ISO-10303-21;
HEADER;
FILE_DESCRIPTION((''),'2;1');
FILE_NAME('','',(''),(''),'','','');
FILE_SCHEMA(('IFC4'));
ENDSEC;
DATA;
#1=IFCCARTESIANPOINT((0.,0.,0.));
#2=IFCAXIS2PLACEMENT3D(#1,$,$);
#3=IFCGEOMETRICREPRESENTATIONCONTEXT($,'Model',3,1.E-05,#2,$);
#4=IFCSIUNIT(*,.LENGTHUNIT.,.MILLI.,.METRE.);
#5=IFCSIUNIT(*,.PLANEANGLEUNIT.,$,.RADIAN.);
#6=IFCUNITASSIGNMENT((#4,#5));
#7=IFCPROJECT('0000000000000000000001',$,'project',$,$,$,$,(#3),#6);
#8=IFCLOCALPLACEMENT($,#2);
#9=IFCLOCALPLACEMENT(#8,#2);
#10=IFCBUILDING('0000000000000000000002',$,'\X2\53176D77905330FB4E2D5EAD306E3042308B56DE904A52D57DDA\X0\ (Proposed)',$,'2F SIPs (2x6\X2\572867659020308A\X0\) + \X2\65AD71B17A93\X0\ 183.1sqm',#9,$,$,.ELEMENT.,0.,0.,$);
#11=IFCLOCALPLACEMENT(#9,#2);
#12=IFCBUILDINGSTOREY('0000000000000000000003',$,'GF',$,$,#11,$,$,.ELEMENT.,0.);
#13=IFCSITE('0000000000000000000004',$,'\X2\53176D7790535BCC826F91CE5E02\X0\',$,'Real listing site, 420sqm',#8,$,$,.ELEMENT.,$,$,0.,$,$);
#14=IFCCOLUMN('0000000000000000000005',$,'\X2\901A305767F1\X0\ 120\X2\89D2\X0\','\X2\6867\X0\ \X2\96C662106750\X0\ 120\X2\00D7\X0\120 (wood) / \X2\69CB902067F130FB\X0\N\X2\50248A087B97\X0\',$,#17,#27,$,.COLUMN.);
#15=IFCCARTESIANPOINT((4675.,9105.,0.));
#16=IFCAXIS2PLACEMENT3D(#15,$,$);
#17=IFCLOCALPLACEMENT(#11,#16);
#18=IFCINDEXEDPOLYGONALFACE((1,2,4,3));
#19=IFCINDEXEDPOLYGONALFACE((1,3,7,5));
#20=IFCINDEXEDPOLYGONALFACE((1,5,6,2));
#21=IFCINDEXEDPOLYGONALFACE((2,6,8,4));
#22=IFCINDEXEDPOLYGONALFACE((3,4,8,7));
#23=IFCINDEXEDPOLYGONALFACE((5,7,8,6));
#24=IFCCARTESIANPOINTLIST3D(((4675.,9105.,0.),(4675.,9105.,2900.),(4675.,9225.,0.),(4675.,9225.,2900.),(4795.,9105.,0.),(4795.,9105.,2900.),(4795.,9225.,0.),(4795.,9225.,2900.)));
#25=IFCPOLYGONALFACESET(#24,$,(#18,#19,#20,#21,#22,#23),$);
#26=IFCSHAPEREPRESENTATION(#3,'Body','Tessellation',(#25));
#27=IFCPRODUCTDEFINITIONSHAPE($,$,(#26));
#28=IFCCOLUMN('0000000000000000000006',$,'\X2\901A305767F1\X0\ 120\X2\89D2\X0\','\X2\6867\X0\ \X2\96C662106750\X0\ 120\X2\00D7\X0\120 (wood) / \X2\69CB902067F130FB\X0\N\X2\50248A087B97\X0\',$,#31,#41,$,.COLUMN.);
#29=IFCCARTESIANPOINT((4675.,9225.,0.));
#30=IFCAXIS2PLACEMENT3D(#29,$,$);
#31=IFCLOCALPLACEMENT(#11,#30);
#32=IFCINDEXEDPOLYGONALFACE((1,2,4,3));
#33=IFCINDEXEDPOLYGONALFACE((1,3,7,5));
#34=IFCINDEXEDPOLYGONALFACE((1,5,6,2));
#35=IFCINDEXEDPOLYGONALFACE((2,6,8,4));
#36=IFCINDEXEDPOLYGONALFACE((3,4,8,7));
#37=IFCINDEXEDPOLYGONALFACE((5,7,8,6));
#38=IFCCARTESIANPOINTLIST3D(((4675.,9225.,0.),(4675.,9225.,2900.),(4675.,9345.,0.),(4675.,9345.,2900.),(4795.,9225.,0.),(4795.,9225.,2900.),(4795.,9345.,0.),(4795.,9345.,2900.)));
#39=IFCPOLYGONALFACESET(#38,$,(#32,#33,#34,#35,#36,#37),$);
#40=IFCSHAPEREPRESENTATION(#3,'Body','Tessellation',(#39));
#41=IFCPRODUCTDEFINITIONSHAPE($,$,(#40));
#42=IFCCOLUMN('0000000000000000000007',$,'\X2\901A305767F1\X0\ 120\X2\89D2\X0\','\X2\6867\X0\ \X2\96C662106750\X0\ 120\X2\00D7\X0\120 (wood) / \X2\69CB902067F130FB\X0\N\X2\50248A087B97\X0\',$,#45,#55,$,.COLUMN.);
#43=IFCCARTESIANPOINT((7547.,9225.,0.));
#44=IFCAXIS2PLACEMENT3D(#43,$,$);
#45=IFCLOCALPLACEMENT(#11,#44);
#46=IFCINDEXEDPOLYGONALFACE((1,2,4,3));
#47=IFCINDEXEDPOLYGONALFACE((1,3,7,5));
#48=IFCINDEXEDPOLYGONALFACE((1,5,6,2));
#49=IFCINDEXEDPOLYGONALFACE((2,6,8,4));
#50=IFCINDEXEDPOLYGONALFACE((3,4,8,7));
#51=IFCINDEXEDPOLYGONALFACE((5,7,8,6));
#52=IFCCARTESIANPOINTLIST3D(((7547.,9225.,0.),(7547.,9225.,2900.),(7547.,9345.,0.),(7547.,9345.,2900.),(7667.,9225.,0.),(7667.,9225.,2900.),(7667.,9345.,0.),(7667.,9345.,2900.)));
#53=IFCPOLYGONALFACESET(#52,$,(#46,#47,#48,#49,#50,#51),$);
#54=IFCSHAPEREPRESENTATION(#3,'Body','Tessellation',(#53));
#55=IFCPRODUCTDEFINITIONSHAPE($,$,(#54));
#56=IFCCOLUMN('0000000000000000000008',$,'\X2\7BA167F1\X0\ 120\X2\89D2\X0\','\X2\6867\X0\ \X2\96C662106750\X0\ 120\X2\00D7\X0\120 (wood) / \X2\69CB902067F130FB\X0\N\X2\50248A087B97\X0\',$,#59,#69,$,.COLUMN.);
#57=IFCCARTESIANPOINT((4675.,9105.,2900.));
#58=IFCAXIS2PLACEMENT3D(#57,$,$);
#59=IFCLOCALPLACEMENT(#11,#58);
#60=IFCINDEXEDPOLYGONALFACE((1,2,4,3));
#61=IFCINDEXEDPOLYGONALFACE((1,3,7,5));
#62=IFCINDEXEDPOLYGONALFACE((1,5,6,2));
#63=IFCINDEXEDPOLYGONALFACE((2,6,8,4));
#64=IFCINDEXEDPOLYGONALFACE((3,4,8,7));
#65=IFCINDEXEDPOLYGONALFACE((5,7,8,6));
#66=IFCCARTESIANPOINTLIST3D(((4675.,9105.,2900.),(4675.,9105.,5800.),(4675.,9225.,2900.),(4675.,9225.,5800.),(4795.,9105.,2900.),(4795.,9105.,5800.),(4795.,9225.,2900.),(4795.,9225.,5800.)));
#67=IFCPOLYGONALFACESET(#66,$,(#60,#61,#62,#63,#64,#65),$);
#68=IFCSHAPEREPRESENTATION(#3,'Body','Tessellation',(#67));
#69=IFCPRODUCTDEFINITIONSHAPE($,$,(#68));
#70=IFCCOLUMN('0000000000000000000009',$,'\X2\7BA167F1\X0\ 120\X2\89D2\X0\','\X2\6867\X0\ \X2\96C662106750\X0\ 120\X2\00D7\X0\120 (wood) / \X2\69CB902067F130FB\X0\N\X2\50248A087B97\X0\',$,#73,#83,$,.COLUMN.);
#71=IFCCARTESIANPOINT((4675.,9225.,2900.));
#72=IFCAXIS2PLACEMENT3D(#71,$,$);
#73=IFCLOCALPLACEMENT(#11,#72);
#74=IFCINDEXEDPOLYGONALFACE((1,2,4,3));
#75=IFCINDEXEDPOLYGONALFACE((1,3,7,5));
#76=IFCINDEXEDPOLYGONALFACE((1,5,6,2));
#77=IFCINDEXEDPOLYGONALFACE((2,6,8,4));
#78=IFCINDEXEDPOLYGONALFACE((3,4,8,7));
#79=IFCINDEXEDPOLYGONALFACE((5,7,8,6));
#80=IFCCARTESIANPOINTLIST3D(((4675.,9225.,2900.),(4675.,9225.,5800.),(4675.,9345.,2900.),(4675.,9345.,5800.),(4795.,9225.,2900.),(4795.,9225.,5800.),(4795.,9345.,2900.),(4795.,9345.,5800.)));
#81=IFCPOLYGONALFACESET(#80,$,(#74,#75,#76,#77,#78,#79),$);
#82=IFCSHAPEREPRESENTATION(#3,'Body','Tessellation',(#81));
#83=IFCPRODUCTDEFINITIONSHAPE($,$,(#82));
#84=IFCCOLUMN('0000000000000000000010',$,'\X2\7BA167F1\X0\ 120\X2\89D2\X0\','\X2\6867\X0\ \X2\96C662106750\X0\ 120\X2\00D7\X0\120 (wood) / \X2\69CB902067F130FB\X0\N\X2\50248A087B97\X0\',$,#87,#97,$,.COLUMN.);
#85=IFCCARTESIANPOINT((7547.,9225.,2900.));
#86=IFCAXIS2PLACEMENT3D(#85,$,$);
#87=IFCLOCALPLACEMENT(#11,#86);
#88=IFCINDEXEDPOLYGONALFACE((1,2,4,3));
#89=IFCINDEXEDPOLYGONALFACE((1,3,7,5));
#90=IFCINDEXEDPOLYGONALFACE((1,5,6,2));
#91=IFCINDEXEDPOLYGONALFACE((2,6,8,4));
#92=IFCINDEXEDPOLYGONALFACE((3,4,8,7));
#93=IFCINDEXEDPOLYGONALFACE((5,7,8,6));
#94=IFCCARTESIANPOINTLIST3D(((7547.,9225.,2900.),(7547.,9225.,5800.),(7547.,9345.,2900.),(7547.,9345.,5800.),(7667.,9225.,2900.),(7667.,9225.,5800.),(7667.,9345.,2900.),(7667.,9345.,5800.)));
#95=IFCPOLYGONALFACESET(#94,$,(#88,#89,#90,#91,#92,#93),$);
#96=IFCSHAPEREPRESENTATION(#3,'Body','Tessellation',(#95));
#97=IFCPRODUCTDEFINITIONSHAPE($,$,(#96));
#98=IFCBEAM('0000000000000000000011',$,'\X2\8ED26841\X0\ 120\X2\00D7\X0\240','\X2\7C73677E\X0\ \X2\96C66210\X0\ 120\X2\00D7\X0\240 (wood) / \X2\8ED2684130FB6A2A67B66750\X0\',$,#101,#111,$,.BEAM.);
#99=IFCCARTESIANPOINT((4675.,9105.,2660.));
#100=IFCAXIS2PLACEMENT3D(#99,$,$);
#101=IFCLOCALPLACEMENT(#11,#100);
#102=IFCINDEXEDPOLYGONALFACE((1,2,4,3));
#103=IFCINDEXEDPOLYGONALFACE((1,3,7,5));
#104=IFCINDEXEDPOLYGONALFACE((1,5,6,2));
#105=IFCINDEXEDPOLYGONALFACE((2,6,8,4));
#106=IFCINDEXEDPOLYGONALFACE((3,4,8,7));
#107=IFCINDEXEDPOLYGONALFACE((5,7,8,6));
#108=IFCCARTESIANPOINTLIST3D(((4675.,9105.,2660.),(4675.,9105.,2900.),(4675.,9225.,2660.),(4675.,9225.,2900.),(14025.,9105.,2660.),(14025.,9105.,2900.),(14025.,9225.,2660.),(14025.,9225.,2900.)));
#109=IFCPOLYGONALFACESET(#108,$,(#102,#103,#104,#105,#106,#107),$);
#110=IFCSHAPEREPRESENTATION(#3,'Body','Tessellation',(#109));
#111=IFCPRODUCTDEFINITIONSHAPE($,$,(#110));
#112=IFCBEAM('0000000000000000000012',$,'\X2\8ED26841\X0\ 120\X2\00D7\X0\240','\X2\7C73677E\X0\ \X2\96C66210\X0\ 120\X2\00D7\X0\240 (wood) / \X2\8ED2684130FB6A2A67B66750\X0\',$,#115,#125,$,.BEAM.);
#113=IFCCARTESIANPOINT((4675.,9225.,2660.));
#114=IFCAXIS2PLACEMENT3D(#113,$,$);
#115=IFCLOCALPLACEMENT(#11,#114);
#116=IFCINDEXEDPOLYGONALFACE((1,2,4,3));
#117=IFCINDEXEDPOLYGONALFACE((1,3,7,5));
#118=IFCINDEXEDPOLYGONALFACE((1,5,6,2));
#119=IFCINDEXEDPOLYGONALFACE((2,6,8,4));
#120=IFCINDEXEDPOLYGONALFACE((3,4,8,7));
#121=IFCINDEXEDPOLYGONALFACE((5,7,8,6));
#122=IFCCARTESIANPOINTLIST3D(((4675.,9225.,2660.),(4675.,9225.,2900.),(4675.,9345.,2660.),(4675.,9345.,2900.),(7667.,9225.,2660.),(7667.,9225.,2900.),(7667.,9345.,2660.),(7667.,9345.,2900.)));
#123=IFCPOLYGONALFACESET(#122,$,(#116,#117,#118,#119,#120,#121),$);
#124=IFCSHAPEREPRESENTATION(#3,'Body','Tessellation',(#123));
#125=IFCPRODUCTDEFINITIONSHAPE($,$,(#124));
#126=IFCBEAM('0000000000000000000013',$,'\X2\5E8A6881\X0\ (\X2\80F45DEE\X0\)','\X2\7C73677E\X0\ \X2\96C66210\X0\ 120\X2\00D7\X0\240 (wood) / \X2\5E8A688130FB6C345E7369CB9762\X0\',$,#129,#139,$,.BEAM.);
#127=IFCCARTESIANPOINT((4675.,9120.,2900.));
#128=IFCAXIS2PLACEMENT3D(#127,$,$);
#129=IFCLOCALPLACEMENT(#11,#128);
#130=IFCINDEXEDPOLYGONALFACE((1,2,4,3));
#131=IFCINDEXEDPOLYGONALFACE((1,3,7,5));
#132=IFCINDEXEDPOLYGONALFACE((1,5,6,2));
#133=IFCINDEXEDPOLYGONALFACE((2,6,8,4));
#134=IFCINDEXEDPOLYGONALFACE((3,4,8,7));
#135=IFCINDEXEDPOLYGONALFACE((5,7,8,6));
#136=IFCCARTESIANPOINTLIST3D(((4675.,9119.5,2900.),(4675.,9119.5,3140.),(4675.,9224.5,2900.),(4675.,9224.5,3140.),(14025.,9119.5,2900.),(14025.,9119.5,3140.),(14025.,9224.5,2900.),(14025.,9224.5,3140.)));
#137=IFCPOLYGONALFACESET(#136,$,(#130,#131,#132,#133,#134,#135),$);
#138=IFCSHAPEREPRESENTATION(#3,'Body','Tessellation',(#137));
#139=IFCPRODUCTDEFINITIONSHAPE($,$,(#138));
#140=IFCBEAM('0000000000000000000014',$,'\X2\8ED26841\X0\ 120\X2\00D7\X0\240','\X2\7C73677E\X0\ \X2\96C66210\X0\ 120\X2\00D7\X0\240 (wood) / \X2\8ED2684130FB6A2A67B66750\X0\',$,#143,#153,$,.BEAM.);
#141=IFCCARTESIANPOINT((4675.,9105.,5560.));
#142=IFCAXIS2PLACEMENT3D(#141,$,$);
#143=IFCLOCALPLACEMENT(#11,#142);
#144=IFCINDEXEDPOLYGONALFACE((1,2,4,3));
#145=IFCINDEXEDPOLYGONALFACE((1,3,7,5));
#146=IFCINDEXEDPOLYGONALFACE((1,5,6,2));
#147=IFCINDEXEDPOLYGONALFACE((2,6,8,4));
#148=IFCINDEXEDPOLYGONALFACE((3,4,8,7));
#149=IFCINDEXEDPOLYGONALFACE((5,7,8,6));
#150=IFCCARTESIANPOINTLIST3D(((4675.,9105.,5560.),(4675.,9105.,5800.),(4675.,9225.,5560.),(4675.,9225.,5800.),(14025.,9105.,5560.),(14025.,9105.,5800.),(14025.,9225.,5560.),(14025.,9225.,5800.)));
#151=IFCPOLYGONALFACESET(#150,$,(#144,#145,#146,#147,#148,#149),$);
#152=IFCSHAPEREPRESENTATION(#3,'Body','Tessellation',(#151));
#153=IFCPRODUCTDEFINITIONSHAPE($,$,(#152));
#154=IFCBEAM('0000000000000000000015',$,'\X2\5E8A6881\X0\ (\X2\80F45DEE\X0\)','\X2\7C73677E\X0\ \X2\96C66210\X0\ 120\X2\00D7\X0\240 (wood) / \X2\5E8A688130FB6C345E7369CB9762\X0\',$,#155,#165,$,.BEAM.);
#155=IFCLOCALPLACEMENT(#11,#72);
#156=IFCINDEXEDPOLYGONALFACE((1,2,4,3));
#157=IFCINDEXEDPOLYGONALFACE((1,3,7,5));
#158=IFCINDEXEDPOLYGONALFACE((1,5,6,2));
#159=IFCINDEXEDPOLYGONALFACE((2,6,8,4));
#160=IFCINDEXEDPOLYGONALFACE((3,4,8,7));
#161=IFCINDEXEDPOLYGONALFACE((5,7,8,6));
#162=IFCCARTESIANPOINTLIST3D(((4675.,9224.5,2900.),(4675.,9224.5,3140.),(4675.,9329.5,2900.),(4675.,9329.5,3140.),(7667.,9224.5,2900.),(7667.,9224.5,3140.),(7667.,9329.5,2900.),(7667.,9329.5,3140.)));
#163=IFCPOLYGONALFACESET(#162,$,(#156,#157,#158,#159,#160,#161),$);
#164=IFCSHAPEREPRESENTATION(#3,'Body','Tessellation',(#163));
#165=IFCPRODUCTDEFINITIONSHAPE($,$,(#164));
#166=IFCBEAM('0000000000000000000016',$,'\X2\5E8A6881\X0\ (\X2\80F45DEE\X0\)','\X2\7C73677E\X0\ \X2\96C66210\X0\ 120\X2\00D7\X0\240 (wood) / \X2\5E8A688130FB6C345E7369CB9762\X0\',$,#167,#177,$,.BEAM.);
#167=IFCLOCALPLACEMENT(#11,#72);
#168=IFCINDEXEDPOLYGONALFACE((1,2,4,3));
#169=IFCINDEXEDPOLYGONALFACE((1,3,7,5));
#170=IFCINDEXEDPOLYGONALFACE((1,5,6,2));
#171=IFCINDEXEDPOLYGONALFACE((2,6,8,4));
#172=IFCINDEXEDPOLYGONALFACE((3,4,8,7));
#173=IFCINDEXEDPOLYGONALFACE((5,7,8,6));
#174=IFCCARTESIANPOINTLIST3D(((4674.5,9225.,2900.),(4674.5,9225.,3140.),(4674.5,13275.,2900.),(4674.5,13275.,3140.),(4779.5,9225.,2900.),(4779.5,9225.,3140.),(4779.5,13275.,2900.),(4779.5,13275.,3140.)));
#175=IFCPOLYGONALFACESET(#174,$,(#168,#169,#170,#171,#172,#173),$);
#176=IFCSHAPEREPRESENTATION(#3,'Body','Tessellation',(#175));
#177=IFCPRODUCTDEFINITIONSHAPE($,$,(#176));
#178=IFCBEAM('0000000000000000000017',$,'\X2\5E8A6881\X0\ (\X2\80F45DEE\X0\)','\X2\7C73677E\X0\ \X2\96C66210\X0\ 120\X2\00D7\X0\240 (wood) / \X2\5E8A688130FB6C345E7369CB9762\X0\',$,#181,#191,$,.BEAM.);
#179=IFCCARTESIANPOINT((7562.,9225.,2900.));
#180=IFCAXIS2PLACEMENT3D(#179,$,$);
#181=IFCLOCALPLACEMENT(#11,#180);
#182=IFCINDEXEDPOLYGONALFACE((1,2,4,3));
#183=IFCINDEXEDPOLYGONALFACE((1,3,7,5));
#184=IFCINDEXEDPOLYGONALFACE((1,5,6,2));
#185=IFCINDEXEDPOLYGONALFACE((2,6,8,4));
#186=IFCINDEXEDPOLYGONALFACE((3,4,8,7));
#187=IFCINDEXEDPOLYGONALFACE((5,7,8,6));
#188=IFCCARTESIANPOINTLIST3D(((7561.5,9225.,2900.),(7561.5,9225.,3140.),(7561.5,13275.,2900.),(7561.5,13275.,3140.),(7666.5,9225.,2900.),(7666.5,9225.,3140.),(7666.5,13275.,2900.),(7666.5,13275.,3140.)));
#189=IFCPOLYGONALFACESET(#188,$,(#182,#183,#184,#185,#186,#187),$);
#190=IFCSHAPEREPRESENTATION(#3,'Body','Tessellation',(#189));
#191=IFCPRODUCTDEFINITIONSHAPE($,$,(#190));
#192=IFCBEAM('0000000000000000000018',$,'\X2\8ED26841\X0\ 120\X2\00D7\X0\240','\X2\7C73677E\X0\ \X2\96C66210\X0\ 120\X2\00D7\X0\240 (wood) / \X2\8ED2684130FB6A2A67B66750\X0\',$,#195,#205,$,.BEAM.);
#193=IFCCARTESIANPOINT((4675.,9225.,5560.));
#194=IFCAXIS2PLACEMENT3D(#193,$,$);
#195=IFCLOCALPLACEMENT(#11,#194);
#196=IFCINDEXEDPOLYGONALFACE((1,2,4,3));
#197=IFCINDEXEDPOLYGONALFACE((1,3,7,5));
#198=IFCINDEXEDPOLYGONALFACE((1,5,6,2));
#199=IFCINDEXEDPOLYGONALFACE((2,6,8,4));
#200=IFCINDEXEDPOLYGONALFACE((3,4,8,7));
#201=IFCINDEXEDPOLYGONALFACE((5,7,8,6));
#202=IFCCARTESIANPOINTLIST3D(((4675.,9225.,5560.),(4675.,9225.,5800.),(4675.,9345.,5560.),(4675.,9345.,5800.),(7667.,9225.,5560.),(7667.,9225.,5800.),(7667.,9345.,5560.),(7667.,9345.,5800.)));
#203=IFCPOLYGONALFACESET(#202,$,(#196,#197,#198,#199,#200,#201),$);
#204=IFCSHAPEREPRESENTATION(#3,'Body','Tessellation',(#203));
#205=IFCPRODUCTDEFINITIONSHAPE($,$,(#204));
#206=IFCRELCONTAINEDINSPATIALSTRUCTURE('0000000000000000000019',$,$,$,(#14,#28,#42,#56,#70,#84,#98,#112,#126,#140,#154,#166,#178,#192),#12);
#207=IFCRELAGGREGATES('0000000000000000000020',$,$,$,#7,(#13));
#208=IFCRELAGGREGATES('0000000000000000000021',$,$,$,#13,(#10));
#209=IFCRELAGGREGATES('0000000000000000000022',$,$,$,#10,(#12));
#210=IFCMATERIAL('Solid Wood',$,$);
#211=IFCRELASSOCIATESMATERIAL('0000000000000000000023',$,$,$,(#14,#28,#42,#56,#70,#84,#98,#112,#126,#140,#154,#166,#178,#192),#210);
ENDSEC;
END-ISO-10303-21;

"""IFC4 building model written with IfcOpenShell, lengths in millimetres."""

from ifc_helpers import new_model, si_unit, frame, frame_2d, origin, place, context, project, spatial, rectangle, extrude, material, element, save


model = new_model("IFC4")

# Units and contexts
model_context = context("Model", 3, precision=1e-05, world=origin())
ifc_project = project(units=[si_unit("LENGTHUNIT", "METRE", prefix="MILLI"), si_unit("PLANEANGLEUNIT", "RADIAN")], contexts=[model_context])

# Site, building, storey
site_placement = place(None, origin())
site = spatial("IfcSite", under=ifc_project, at=site_placement, Name="北海道富良野市", ObjectType="Real listing site, 420sqm", CompositionType="ELEMENT", RefElevation=0.0)
building_placement = place(site_placement, origin())
building = spatial("IfcBuilding", under=site, at=building_placement, Name="北海道・中庭のある回遊動線 (Proposed)", ObjectType="2F SIPs (2x6在来造り) + 断熱窓 183.1sqm", CompositionType="ELEMENT", ElevationOfRefHeight=0.0, ElevationOfTerrain=0.0)
storey_placement = place(building_placement, origin())
storey = spatial("IfcBuildingStorey", under=building, at=storey_placement, Name="GF", CompositionType="ELEMENT", Elevation=0.0)

# Columns
ifc_material_1 = material(Name="Solid Wood")
column_1_placement = place(storey_placement, frame((4675.0, 9105.0, 0.0)))
element("IfcColumn", 1, at=column_1_placement, inside=storey, material=ifc_material_1, Name="通し柱 120角", Description="桧 集成材 120×120 (wood) / 構造柱・N値計算", PredefinedType="COLUMN", context=model_context, shape_type="SweptSolid", body=[
    extrude(rectangle(XDim=120.0, YDim=120.0, at=frame_2d((60.0, 60.0))), frame((4675.0, 9105.0, 0.0)), (0.0, 0.0, 1.0), 2900.0),
])
column_2_placement = place(storey_placement, frame((4675.0, 9225.0, 0.0)))
element("IfcColumn", 2, at=column_2_placement, inside=storey, material=ifc_material_1, Name="通し柱 120角", Description="桧 集成材 120×120 (wood) / 構造柱・N値計算", PredefinedType="COLUMN", context=model_context, shape_type="SweptSolid", body=[
    extrude(rectangle(XDim=120.0, YDim=120.0, at=frame_2d((60.0, 60.0))), frame((4675.0, 9225.0, 0.0)), (0.0, 0.0, 1.0), 2900.0),
])
column_3_placement = place(storey_placement, frame((7547.0, 9225.0, 0.0)))
element("IfcColumn", 3, at=column_3_placement, inside=storey, material=ifc_material_1, Name="通し柱 120角", Description="桧 集成材 120×120 (wood) / 構造柱・N値計算", PredefinedType="COLUMN", context=model_context, shape_type="SweptSolid", body=[
    extrude(rectangle(XDim=120.0, YDim=120.0, at=frame_2d((60.0, 60.0))), frame((7547.0, 9225.0, 0.0)), (0.0, 0.0, 1.0), 2900.0),
])
column_4_placement = place(storey_placement, frame((4675.0, 9105.0, 2900.0)))
element("IfcColumn", 4, at=column_4_placement, inside=storey, material=ifc_material_1, Name="管柱 120角", Description="桧 集成材 120×120 (wood) / 構造柱・N値計算", PredefinedType="COLUMN", context=model_context, shape_type="SweptSolid", body=[
    extrude(rectangle(XDim=120.0, YDim=120.0, at=frame_2d((60.0, 60.0))), frame((4675.0, 9105.0, 2900.0)), (0.0, 0.0, 1.0), 2900.0),
])
column_5_placement = place(storey_placement, frame((4675.0, 9225.0, 2900.0)))
element("IfcColumn", 5, at=column_5_placement, inside=storey, material=ifc_material_1, Name="管柱 120角", Description="桧 集成材 120×120 (wood) / 構造柱・N値計算", PredefinedType="COLUMN", context=model_context, shape_type="SweptSolid", body=[
    extrude(rectangle(XDim=120.0, YDim=120.0, at=frame_2d((60.0, 60.0))), frame((4675.0, 9225.0, 2900.0)), (0.0, 0.0, 1.0), 2900.0),
])
column_6_placement = place(storey_placement, frame((7547.0, 9225.0, 2900.0)))
element("IfcColumn", 6, at=column_6_placement, inside=storey, material=ifc_material_1, Name="管柱 120角", Description="桧 集成材 120×120 (wood) / 構造柱・N値計算", PredefinedType="COLUMN", context=model_context, shape_type="SweptSolid", body=[
    extrude(rectangle(XDim=120.0, YDim=120.0, at=frame_2d((60.0, 60.0))), frame((7547.0, 9225.0, 2900.0)), (0.0, 0.0, 1.0), 2900.0),
])

# Beams
beam_1_placement = place(storey_placement, frame((4675.0, 9105.0, 2660.0)))
element("IfcBeam", 7, at=beam_1_placement, inside=storey, material=ifc_material_1, Name="軒桁 120×240", Description="米松 集成 120×240 (wood) / 軒桁・横架材", PredefinedType="BEAM", context=model_context, shape_type="SweptSolid", body=[
    extrude(rectangle(XDim=9350.0, YDim=120.0, at=frame_2d((4675.0, 60.0))), frame((4675.0, 9105.0, 2660.0)), (0.0, 0.0, 1.0), 240.0),
])
beam_2_placement = place(storey_placement, frame((4675.0, 9225.0, 2660.0)))
element("IfcBeam", 8, at=beam_2_placement, inside=storey, material=ifc_material_1, Name="軒桁 120×240", Description="米松 集成 120×240 (wood) / 軒桁・横架材", PredefinedType="BEAM", context=model_context, shape_type="SweptSolid", body=[
    extrude(rectangle(XDim=2992.0, YDim=120.0, at=frame_2d((1496.0, 60.0))), frame((4675.0, 9225.0, 2660.0)), (0.0, 0.0, 1.0), 240.0),
])
beam_3_placement = place(storey_placement, frame((4675.0, 9120.0, 2900.0)))
element("IfcBeam", 9, at=beam_3_placement, inside=storey, material=ifc_material_1, Name="床梁 (胴差)", Description="米松 集成 120×240 (wood) / 床梁・水平構面", PredefinedType="BEAM", context=model_context, shape_type="SweptSolid", body=[
    extrude(rectangle(XDim=9350.0, YDim=105.0, at=frame_2d((4675.0, 52.0))), frame((4675.0, 9120.0, 2900.0)), (0.0, 0.0, 1.0), 240.0),
])
beam_4_placement = place(storey_placement, frame((4675.0, 9105.0, 5560.0)))
element("IfcBeam", 10, at=beam_4_placement, inside=storey, material=ifc_material_1, Name="軒桁 120×240", Description="米松 集成 120×240 (wood) / 軒桁・横架材", PredefinedType="BEAM", context=model_context, shape_type="SweptSolid", body=[
    extrude(rectangle(XDim=9350.0, YDim=120.0, at=frame_2d((4675.0, 60.0))), frame((4675.0, 9105.0, 5560.0)), (0.0, 0.0, 1.0), 240.0),
])
beam_5_placement = place(storey_placement, frame((4675.0, 9225.0, 2900.0)))
element("IfcBeam", 11, at=beam_5_placement, inside=storey, material=ifc_material_1, Name="床梁 (胴差)", Description="米松 集成 120×240 (wood) / 床梁・水平構面", PredefinedType="BEAM", context=model_context, shape_type="SweptSolid", body=[
    extrude(rectangle(XDim=2992.0, YDim=105.0, at=frame_2d((1496.0, 52.0))), frame((4675.0, 9225.0, 2900.0)), (0.0, 0.0, 1.0), 240.0),
])
beam_6_placement = place(storey_placement, frame((4675.0, 9225.0, 2900.0)))
element("IfcBeam", 12, at=beam_6_placement, inside=storey, material=ifc_material_1, Name="床梁 (胴差)", Description="米松 集成 120×240 (wood) / 床梁・水平構面", PredefinedType="BEAM", context=model_context, shape_type="SweptSolid", body=[
    extrude(rectangle(XDim=105.0, YDim=4050.0, at=frame_2d((52.0, 2025.0))), frame((4675.0, 9225.0, 2900.0)), (0.0, 0.0, 1.0), 240.0),
])
beam_7_placement = place(storey_placement, frame((7562.0, 9225.0, 2900.0)))
element("IfcBeam", 13, at=beam_7_placement, inside=storey, material=ifc_material_1, Name="床梁 (胴差)", Description="米松 集成 120×240 (wood) / 床梁・水平構面", PredefinedType="BEAM", context=model_context, shape_type="SweptSolid", body=[
    extrude(rectangle(XDim=105.0, YDim=4050.0, at=frame_2d((52.0, 2025.0))), frame((7562.0, 9225.0, 2900.0)), (0.0, 0.0, 1.0), 240.0),
])
beam_8_placement = place(storey_placement, frame((4675.0, 9225.0, 5560.0)))
element("IfcBeam", 14, at=beam_8_placement, inside=storey, material=ifc_material_1, Name="軒桁 120×240", Description="米松 集成 120×240 (wood) / 軒桁・横架材", PredefinedType="BEAM", context=model_context, shape_type="SweptSolid", body=[
    extrude(rectangle(XDim=2992.0, YDim=120.0, at=frame_2d((1496.0, 60.0))), frame((4675.0, 9225.0, 5560.0)), (0.0, 0.0, 1.0), 240.0),
])

save(model, "model.ifc")
